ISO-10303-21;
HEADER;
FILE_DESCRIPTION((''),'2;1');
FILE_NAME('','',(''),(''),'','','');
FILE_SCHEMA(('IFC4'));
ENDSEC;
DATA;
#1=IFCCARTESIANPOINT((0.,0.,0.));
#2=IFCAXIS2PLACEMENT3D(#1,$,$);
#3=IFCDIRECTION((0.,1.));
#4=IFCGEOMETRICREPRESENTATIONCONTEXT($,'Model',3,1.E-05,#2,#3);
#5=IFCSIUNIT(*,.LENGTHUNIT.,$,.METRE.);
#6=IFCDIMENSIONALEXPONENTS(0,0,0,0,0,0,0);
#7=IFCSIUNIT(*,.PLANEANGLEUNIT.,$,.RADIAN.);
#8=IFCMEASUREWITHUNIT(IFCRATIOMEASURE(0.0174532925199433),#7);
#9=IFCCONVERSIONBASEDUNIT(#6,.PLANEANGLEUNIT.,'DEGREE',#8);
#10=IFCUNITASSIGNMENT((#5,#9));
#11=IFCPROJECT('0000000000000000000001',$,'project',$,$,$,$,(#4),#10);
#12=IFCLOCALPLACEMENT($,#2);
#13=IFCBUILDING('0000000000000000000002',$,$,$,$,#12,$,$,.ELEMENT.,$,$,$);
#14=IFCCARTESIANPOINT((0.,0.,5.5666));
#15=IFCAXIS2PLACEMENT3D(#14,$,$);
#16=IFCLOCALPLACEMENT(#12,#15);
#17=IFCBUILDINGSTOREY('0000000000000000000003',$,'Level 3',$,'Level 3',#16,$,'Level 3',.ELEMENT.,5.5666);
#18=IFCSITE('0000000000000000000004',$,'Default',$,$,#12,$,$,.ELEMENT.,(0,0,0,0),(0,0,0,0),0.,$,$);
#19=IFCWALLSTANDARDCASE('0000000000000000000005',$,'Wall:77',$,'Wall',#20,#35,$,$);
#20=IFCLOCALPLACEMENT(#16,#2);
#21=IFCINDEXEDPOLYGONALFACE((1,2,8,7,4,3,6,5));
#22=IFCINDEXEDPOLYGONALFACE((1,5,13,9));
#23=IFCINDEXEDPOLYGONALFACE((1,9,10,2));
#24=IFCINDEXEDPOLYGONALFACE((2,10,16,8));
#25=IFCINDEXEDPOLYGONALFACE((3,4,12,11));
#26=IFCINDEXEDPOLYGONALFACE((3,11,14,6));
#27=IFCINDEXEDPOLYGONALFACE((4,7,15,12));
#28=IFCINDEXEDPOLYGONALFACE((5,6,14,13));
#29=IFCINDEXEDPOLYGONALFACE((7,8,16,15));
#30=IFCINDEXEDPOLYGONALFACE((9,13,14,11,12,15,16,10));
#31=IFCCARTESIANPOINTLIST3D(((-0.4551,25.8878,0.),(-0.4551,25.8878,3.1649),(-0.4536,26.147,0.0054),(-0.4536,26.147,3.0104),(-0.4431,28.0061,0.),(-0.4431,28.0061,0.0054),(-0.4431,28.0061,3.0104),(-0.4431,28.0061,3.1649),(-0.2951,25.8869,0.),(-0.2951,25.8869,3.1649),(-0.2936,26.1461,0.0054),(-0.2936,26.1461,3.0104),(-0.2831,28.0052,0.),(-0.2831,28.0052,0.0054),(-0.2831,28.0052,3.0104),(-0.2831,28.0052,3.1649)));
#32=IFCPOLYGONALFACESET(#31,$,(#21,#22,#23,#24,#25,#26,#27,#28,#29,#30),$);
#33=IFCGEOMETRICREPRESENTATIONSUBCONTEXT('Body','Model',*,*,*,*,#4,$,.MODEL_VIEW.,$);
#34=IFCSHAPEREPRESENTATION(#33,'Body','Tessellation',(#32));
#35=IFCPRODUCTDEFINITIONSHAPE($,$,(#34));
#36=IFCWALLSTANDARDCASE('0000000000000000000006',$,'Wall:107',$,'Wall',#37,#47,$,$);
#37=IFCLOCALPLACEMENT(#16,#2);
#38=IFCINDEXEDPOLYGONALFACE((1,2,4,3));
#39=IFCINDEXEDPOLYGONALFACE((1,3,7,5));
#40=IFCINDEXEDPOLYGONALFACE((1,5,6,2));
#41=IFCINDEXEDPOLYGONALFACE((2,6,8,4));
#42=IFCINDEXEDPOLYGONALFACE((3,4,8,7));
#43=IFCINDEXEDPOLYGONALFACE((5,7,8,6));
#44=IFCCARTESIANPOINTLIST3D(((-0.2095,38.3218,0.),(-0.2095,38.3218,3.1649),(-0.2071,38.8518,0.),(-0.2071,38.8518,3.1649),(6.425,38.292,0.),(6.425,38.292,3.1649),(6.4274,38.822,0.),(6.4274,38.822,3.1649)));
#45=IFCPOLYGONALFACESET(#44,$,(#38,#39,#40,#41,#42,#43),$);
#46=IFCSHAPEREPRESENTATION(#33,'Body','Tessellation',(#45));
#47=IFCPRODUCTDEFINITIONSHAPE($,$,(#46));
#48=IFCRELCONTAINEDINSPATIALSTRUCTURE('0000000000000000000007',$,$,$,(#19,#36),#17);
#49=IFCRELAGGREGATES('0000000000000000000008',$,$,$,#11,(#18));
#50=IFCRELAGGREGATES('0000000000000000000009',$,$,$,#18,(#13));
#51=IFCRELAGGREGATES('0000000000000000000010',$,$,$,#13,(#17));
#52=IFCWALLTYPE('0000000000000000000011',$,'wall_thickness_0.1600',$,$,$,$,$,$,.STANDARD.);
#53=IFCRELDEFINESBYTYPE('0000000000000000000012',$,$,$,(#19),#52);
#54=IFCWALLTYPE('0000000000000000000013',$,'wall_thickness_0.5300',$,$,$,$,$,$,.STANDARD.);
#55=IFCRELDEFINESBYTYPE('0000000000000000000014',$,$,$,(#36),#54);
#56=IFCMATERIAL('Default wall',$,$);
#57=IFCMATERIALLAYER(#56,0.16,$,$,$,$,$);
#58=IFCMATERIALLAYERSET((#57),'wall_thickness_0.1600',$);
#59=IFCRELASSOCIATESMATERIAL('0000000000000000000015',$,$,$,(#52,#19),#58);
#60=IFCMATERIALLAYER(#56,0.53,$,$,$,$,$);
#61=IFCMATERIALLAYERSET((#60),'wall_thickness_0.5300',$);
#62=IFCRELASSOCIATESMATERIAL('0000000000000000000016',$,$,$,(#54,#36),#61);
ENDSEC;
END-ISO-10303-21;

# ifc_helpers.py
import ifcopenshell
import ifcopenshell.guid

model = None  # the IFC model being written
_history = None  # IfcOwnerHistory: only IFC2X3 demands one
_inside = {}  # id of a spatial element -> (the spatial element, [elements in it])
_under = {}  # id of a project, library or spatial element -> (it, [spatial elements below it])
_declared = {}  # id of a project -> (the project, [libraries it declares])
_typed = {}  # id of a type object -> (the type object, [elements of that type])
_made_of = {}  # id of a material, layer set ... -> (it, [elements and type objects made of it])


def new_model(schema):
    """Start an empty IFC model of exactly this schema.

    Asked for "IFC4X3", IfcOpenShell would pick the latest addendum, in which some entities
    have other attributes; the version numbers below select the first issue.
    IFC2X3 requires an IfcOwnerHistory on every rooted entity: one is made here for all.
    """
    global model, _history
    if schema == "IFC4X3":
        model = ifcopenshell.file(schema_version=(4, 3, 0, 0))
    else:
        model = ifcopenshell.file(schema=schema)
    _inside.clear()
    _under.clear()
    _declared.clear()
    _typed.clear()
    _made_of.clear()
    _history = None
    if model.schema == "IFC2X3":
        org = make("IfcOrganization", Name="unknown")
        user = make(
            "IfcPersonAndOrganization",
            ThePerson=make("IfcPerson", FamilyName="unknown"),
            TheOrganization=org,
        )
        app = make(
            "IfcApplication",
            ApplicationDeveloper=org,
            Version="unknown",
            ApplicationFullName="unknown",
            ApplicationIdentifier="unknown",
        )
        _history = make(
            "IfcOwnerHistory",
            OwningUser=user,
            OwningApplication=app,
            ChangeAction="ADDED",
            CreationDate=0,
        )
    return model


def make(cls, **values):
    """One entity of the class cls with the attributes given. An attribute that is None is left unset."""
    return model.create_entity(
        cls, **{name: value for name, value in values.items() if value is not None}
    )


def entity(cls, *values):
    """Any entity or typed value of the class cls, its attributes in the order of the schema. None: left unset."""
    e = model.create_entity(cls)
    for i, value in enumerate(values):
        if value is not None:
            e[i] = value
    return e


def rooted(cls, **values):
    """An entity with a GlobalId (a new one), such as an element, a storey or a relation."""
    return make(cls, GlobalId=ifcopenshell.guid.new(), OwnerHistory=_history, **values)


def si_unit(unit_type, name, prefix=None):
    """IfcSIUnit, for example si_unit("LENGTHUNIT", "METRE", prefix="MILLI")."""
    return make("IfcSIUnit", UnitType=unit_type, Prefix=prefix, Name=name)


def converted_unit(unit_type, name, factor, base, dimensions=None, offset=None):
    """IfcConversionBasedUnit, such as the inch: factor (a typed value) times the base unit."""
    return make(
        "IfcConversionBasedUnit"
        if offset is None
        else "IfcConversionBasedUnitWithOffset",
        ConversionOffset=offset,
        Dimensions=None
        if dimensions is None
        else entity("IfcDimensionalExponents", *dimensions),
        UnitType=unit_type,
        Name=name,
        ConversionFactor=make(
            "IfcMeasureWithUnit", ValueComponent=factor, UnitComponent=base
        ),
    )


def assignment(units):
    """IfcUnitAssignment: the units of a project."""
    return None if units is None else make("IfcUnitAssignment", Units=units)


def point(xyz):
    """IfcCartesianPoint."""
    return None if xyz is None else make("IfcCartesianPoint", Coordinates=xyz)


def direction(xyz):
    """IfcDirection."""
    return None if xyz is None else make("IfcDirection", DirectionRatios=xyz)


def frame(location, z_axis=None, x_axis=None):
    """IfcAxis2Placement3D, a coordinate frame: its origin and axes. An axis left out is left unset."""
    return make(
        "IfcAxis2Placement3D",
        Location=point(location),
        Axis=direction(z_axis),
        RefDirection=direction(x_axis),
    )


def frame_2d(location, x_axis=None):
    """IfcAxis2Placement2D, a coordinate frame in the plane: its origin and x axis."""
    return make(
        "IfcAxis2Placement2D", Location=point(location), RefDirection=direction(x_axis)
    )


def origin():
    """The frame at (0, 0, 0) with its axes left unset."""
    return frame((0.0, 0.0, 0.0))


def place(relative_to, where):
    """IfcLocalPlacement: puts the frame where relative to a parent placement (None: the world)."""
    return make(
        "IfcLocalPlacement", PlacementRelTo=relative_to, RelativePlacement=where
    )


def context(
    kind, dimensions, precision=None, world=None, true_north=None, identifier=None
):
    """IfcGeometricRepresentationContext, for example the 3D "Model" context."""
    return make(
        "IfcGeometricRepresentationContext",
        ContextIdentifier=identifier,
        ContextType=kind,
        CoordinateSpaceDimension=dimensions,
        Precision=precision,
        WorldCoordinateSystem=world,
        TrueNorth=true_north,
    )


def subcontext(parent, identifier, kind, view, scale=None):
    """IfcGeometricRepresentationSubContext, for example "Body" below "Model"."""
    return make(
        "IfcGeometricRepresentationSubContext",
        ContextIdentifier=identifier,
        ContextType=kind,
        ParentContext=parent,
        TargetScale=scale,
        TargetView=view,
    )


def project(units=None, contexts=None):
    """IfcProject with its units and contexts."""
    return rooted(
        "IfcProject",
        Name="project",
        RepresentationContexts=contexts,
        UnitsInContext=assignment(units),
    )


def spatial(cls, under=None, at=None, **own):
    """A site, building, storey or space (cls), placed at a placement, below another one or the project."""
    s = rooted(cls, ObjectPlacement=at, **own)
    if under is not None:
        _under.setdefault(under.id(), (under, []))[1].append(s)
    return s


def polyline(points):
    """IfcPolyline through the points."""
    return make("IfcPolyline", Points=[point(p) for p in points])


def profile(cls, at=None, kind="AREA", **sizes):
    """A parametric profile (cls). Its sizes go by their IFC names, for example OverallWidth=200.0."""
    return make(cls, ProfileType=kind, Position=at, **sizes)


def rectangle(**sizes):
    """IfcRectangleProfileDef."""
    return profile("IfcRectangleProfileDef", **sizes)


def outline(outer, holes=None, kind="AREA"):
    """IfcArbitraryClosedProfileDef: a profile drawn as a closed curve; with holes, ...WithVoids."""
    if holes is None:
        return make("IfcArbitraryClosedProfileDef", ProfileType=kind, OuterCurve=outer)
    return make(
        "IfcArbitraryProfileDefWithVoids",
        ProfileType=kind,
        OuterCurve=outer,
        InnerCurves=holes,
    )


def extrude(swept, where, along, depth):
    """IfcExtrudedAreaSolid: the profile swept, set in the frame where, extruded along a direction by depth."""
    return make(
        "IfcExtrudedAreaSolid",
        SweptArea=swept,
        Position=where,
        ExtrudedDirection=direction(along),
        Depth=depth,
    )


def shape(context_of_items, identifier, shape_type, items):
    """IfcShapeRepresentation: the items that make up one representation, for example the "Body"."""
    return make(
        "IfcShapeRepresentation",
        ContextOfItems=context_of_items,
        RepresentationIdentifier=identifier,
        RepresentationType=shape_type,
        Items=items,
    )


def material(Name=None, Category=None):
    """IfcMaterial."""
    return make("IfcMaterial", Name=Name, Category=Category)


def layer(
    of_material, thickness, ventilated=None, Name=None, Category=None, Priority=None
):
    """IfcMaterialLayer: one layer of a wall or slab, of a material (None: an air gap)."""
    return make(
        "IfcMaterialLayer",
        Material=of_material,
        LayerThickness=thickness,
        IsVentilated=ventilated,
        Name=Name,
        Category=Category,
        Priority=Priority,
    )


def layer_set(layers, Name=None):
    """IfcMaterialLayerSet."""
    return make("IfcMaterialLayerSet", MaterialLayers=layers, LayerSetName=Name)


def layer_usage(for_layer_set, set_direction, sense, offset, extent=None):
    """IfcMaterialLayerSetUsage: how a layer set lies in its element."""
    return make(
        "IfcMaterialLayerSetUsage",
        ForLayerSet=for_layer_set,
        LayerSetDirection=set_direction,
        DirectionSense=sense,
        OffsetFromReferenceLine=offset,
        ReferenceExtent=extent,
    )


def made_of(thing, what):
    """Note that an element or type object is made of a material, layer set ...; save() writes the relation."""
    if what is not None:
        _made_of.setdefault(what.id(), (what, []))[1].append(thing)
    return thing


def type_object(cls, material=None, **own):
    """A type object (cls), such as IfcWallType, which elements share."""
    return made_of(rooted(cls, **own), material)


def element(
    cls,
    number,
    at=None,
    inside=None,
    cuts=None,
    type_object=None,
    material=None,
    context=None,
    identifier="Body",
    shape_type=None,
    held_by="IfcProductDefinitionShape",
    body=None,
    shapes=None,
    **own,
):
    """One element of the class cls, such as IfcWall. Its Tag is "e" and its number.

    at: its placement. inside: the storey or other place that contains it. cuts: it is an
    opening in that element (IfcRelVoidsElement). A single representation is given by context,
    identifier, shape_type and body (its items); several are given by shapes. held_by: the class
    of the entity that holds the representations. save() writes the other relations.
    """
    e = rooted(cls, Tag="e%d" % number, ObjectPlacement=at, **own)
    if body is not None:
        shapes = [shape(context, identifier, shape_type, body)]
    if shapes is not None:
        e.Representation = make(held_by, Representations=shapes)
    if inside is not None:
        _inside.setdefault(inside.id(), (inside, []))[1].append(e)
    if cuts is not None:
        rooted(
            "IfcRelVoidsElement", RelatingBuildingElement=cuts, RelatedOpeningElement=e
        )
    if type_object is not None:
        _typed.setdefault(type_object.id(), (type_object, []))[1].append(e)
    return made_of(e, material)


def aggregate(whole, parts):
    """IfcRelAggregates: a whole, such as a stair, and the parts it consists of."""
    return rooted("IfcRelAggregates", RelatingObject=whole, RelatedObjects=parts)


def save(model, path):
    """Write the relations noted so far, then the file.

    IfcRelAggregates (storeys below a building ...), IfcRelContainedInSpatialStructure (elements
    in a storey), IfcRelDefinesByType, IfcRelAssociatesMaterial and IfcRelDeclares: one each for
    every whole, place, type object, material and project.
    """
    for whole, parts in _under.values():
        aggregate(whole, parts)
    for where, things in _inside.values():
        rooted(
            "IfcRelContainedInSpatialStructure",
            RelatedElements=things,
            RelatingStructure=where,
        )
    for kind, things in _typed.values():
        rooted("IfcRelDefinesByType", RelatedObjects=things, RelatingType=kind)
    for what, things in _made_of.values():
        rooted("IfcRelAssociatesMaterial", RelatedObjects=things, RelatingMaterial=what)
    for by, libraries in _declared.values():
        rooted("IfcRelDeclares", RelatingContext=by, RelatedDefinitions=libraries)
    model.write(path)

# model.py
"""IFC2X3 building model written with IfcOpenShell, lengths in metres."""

from ifc_helpers import new_model, entity, si_unit, converted_unit, direction, frame, frame_2d, origin, place, context, subcontext, project, spatial, polyline, rectangle, outline, extrude, material, layer, layer_set, layer_usage, type_object, element, save


model = new_model("IFC2X3")

# Units and contexts
model_context = context("Model", 3, precision=1e-05, world=origin(), true_north=direction((0.0, 1.0)))
body_context = subcontext(model_context, "Body", "Model", "MODEL_VIEW")
ifc_project = project(units=[si_unit("LENGTHUNIT", "METRE"), converted_unit("PLANEANGLEUNIT", "DEGREE", entity("IfcRatioMeasure", 0.0174532925199433), si_unit("PLANEANGLEUNIT", "RADIAN"), dimensions=[0, 0, 0, 0, 0, 0, 0])], contexts=[model_context])

# Site, building, storey
placement_1 = place(None, origin())
site = spatial("IfcSite", under=ifc_project, at=placement_1, Name="Default", CompositionType="ELEMENT", RefLatitude=(0, 0, 0, 0), RefLongitude=(0, 0, 0, 0), RefElevation=0.0)
building = spatial("IfcBuilding", under=site, at=placement_1, CompositionType="ELEMENT")
storey_placement = place(placement_1, frame((0.0, 0.0, 5.5666)))
storey = spatial("IfcBuildingStorey", under=building, at=storey_placement, Name="Level 3", ObjectType="Level 3", LongName="Level 3", CompositionType="ELEMENT", Elevation=5.5666)

# Shared definitions
ifc_material_1 = material(Name="Default wall")

# Wall, opening
ifc_layer_1 = layer(ifc_material_1, 0.16)
ifc_layer_set_1 = layer_set([ifc_layer_1], Name="wall_thickness_0.1600")
ifc_layer_usage_1 = layer_usage(ifc_layer_set_1, "AXIS2", "POSITIVE", -0.08)
wall_type_1 = type_object("IfcWallType", Name="wall_thickness_0.1600", PredefinedType="STANDARD", material=ifc_layer_set_1)
wall_1_placement = place(storey_placement, frame((-0.3631, 28.0057, 0.0), z_axis=(0.0, 0.0, 1.0), x_axis=(-0.005654, -0.999984, 0.0)))
wall_1 = element("IfcWallStandardCase", 1, at=wall_1_placement, inside=storey, type_object=wall_type_1, material=ifc_layer_usage_1, Name="Wall:77", ObjectType="Wall", context=body_context, shape_type="SweptSolid", body=[
    extrude(outline(polyline([(2.1184, -0.08), (2.1184, 0.08), (0.0, 0.08), (0.0, -0.08), (2.1184, -0.08)])), origin(), (0.0, 0.0, 1.0), 3.1649),
])
opening_1_placement = place(wall_1_placement, frame((-0.1008, -0.08, 0.0054)))
element("IfcOpeningElement", 2, at=opening_1_placement, cuts=wall_1, ObjectType="Opening", context=body_context, shape_type="SweptSolid", body=[
    extrude(rectangle(XDim=1.96, YDim=3.005, at=frame_2d((1.5025, 0.98), x_axis=(0.0, 1.0))), frame((0.0, 0.0, 0.0), z_axis=(0.0, 1.0, 0.0), x_axis=(0.0, 0.0, 1.0)), (0.0, 0.0, 1.0), 0.16),
])

# Wall
ifc_layer_2 = layer(ifc_material_1, 0.53)
ifc_layer_set_2 = layer_set([ifc_layer_2], Name="wall_thickness_0.5300")
ifc_layer_usage_2 = layer_usage(ifc_layer_set_2, "AXIS2", "POSITIVE", -0.265)
wall_type_2 = type_object("IfcWallType", Name="wall_thickness_0.5300", PredefinedType="STANDARD", material=ifc_layer_set_2)
wall_2_placement = place(storey_placement, frame((-0.2083, 38.5868, 0.0), z_axis=(0.0, 0.0, 1.0), x_axis=(0.99999, -0.004496, 0.0)))
element("IfcWallStandardCase", 3, at=wall_2_placement, inside=storey, type_object=wall_type_2, material=ifc_layer_usage_2, Name="Wall:107", ObjectType="Wall", context=body_context, shape_type="SweptSolid", body=[
    extrude(outline(polyline([(6.6345, -0.265), (6.6345, 0.265), (0.0, 0.265), (0.0, -0.265), (6.6345, -0.265)])), origin(), (0.0, 0.0, 1.0), 3.1649),
])

save(model, "model.ifc")
